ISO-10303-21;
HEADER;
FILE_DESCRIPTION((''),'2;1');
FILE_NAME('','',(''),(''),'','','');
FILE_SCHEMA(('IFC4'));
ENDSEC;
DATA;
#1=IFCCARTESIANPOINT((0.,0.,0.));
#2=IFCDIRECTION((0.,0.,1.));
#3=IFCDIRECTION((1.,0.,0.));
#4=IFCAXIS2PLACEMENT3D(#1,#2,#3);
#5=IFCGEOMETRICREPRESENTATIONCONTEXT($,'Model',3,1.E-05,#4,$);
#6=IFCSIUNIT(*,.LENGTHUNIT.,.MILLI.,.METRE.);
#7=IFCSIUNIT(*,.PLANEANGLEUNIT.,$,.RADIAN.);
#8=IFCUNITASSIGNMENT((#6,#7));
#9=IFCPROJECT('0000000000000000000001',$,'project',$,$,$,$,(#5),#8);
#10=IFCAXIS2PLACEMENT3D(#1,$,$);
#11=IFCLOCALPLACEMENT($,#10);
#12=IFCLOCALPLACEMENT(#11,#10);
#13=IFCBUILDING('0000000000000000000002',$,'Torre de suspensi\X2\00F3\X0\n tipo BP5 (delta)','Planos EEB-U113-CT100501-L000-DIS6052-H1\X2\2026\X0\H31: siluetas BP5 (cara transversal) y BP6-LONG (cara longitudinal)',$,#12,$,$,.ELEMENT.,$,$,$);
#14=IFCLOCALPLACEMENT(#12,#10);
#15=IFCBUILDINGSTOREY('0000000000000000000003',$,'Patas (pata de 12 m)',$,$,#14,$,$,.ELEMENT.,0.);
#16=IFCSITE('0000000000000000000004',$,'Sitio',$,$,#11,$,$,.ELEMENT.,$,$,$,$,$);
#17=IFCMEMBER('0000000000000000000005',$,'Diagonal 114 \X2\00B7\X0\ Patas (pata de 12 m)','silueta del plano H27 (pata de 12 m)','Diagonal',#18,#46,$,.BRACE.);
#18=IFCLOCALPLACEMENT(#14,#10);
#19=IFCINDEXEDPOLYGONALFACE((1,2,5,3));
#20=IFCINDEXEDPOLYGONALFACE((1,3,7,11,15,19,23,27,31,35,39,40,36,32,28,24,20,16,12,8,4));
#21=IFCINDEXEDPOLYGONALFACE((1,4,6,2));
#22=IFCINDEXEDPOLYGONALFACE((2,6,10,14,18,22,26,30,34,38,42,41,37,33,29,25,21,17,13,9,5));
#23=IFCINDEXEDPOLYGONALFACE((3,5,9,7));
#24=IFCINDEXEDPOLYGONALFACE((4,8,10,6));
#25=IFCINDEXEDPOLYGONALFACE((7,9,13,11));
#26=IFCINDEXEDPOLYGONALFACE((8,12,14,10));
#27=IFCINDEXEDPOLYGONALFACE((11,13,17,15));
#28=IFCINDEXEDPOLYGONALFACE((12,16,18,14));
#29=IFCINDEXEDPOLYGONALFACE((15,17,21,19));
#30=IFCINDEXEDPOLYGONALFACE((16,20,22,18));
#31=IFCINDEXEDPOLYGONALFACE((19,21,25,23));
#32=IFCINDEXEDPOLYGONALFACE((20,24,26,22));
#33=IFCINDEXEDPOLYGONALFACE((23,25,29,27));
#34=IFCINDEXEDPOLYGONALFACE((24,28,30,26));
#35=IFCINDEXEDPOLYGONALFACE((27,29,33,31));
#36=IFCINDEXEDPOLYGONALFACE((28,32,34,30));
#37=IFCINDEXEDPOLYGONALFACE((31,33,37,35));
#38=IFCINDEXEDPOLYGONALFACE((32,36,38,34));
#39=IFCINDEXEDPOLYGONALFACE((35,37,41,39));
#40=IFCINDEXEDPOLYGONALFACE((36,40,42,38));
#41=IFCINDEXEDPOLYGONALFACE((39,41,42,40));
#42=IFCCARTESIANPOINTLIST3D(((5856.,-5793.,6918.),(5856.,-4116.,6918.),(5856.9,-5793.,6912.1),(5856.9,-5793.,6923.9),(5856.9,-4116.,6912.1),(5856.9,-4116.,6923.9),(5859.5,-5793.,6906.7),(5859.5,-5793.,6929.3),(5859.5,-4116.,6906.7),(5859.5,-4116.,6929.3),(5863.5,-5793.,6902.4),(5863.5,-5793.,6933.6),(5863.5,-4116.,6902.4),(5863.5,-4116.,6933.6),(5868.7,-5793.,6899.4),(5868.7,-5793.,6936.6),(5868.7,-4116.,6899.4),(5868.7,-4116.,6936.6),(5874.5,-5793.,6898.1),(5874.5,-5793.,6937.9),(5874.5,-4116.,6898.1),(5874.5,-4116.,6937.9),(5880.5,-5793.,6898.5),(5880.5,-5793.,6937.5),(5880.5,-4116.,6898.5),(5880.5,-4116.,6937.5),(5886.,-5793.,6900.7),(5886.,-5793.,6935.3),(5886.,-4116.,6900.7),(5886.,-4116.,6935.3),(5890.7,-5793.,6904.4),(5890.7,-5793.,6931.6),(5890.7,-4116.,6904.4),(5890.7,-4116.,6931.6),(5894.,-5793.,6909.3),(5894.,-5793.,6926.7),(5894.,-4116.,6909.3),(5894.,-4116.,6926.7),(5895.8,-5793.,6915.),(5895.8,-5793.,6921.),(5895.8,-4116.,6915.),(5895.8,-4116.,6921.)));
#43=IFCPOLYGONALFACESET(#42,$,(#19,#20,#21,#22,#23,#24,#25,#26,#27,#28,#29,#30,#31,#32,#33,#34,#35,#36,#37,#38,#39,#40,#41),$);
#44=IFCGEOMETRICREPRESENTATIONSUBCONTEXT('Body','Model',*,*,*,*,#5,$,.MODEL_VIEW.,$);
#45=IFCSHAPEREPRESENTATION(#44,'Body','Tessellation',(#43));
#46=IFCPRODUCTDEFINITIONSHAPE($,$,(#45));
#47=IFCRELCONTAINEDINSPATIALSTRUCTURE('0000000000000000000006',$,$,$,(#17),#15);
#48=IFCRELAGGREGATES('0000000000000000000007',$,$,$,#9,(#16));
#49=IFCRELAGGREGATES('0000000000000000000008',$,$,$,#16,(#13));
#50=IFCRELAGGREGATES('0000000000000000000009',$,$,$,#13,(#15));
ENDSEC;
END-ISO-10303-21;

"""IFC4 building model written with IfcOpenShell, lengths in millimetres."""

from ifc_helpers import new_model, si_unit, frame, origin, origin_with_axes, place, context, subcontext, project, spatial, circle, extrude, element, save


model = new_model("IFC4")

# Units and contexts
model_context = context("Model", 3, precision=1e-05, world=origin_with_axes())
body_context = subcontext(model_context, "Body", "Model", "MODEL_VIEW")
ifc_project = project(units=[si_unit("LENGTHUNIT", "METRE", prefix="MILLI"), si_unit("PLANEANGLEUNIT", "RADIAN")], contexts=[model_context])

# Site, building, storey
site_placement = place(None, origin())
site = spatial("IfcSite", under=ifc_project, at=site_placement, Name="Sitio", CompositionType="ELEMENT")
building_placement = place(site_placement, origin())
building = spatial("IfcBuilding", under=site, at=building_placement, Name="Torre de suspensión tipo BP5 (delta)", Description="Planos EEB-U113-CT100501-L000-DIS6052-H1…H31: siluetas BP5 (cara transversal) y BP6-LONG (cara longitudinal)", CompositionType="ELEMENT")
storey_placement = place(building_placement, origin())
storey = spatial("IfcBuildingStorey", under=building, at=storey_placement, Name="Patas (pata de 12 m)", CompositionType="ELEMENT", Elevation=0.0)

# Member
member_1_placement = place(storey_placement, frame((5876.0, -5793.0, 6918.0), z_axis=(0.0, 1.0, 0.0), x_axis=(-1.0, 0.0, 0.0)))
element("IfcMember", 1, at=member_1_placement, inside=storey, Name="Diagonal 114 · Patas (pata de 12 m)", Description="silueta del plano H27 (pata de 12 m)", ObjectType="Diagonal", PredefinedType="BRACE", context=body_context, shape_type="SweptSolid", body=[
    extrude(circle(Radius=20.0), None, (0.0, 0.0, 1.0), 1677.0),
])

save(model, "model.ifc")
